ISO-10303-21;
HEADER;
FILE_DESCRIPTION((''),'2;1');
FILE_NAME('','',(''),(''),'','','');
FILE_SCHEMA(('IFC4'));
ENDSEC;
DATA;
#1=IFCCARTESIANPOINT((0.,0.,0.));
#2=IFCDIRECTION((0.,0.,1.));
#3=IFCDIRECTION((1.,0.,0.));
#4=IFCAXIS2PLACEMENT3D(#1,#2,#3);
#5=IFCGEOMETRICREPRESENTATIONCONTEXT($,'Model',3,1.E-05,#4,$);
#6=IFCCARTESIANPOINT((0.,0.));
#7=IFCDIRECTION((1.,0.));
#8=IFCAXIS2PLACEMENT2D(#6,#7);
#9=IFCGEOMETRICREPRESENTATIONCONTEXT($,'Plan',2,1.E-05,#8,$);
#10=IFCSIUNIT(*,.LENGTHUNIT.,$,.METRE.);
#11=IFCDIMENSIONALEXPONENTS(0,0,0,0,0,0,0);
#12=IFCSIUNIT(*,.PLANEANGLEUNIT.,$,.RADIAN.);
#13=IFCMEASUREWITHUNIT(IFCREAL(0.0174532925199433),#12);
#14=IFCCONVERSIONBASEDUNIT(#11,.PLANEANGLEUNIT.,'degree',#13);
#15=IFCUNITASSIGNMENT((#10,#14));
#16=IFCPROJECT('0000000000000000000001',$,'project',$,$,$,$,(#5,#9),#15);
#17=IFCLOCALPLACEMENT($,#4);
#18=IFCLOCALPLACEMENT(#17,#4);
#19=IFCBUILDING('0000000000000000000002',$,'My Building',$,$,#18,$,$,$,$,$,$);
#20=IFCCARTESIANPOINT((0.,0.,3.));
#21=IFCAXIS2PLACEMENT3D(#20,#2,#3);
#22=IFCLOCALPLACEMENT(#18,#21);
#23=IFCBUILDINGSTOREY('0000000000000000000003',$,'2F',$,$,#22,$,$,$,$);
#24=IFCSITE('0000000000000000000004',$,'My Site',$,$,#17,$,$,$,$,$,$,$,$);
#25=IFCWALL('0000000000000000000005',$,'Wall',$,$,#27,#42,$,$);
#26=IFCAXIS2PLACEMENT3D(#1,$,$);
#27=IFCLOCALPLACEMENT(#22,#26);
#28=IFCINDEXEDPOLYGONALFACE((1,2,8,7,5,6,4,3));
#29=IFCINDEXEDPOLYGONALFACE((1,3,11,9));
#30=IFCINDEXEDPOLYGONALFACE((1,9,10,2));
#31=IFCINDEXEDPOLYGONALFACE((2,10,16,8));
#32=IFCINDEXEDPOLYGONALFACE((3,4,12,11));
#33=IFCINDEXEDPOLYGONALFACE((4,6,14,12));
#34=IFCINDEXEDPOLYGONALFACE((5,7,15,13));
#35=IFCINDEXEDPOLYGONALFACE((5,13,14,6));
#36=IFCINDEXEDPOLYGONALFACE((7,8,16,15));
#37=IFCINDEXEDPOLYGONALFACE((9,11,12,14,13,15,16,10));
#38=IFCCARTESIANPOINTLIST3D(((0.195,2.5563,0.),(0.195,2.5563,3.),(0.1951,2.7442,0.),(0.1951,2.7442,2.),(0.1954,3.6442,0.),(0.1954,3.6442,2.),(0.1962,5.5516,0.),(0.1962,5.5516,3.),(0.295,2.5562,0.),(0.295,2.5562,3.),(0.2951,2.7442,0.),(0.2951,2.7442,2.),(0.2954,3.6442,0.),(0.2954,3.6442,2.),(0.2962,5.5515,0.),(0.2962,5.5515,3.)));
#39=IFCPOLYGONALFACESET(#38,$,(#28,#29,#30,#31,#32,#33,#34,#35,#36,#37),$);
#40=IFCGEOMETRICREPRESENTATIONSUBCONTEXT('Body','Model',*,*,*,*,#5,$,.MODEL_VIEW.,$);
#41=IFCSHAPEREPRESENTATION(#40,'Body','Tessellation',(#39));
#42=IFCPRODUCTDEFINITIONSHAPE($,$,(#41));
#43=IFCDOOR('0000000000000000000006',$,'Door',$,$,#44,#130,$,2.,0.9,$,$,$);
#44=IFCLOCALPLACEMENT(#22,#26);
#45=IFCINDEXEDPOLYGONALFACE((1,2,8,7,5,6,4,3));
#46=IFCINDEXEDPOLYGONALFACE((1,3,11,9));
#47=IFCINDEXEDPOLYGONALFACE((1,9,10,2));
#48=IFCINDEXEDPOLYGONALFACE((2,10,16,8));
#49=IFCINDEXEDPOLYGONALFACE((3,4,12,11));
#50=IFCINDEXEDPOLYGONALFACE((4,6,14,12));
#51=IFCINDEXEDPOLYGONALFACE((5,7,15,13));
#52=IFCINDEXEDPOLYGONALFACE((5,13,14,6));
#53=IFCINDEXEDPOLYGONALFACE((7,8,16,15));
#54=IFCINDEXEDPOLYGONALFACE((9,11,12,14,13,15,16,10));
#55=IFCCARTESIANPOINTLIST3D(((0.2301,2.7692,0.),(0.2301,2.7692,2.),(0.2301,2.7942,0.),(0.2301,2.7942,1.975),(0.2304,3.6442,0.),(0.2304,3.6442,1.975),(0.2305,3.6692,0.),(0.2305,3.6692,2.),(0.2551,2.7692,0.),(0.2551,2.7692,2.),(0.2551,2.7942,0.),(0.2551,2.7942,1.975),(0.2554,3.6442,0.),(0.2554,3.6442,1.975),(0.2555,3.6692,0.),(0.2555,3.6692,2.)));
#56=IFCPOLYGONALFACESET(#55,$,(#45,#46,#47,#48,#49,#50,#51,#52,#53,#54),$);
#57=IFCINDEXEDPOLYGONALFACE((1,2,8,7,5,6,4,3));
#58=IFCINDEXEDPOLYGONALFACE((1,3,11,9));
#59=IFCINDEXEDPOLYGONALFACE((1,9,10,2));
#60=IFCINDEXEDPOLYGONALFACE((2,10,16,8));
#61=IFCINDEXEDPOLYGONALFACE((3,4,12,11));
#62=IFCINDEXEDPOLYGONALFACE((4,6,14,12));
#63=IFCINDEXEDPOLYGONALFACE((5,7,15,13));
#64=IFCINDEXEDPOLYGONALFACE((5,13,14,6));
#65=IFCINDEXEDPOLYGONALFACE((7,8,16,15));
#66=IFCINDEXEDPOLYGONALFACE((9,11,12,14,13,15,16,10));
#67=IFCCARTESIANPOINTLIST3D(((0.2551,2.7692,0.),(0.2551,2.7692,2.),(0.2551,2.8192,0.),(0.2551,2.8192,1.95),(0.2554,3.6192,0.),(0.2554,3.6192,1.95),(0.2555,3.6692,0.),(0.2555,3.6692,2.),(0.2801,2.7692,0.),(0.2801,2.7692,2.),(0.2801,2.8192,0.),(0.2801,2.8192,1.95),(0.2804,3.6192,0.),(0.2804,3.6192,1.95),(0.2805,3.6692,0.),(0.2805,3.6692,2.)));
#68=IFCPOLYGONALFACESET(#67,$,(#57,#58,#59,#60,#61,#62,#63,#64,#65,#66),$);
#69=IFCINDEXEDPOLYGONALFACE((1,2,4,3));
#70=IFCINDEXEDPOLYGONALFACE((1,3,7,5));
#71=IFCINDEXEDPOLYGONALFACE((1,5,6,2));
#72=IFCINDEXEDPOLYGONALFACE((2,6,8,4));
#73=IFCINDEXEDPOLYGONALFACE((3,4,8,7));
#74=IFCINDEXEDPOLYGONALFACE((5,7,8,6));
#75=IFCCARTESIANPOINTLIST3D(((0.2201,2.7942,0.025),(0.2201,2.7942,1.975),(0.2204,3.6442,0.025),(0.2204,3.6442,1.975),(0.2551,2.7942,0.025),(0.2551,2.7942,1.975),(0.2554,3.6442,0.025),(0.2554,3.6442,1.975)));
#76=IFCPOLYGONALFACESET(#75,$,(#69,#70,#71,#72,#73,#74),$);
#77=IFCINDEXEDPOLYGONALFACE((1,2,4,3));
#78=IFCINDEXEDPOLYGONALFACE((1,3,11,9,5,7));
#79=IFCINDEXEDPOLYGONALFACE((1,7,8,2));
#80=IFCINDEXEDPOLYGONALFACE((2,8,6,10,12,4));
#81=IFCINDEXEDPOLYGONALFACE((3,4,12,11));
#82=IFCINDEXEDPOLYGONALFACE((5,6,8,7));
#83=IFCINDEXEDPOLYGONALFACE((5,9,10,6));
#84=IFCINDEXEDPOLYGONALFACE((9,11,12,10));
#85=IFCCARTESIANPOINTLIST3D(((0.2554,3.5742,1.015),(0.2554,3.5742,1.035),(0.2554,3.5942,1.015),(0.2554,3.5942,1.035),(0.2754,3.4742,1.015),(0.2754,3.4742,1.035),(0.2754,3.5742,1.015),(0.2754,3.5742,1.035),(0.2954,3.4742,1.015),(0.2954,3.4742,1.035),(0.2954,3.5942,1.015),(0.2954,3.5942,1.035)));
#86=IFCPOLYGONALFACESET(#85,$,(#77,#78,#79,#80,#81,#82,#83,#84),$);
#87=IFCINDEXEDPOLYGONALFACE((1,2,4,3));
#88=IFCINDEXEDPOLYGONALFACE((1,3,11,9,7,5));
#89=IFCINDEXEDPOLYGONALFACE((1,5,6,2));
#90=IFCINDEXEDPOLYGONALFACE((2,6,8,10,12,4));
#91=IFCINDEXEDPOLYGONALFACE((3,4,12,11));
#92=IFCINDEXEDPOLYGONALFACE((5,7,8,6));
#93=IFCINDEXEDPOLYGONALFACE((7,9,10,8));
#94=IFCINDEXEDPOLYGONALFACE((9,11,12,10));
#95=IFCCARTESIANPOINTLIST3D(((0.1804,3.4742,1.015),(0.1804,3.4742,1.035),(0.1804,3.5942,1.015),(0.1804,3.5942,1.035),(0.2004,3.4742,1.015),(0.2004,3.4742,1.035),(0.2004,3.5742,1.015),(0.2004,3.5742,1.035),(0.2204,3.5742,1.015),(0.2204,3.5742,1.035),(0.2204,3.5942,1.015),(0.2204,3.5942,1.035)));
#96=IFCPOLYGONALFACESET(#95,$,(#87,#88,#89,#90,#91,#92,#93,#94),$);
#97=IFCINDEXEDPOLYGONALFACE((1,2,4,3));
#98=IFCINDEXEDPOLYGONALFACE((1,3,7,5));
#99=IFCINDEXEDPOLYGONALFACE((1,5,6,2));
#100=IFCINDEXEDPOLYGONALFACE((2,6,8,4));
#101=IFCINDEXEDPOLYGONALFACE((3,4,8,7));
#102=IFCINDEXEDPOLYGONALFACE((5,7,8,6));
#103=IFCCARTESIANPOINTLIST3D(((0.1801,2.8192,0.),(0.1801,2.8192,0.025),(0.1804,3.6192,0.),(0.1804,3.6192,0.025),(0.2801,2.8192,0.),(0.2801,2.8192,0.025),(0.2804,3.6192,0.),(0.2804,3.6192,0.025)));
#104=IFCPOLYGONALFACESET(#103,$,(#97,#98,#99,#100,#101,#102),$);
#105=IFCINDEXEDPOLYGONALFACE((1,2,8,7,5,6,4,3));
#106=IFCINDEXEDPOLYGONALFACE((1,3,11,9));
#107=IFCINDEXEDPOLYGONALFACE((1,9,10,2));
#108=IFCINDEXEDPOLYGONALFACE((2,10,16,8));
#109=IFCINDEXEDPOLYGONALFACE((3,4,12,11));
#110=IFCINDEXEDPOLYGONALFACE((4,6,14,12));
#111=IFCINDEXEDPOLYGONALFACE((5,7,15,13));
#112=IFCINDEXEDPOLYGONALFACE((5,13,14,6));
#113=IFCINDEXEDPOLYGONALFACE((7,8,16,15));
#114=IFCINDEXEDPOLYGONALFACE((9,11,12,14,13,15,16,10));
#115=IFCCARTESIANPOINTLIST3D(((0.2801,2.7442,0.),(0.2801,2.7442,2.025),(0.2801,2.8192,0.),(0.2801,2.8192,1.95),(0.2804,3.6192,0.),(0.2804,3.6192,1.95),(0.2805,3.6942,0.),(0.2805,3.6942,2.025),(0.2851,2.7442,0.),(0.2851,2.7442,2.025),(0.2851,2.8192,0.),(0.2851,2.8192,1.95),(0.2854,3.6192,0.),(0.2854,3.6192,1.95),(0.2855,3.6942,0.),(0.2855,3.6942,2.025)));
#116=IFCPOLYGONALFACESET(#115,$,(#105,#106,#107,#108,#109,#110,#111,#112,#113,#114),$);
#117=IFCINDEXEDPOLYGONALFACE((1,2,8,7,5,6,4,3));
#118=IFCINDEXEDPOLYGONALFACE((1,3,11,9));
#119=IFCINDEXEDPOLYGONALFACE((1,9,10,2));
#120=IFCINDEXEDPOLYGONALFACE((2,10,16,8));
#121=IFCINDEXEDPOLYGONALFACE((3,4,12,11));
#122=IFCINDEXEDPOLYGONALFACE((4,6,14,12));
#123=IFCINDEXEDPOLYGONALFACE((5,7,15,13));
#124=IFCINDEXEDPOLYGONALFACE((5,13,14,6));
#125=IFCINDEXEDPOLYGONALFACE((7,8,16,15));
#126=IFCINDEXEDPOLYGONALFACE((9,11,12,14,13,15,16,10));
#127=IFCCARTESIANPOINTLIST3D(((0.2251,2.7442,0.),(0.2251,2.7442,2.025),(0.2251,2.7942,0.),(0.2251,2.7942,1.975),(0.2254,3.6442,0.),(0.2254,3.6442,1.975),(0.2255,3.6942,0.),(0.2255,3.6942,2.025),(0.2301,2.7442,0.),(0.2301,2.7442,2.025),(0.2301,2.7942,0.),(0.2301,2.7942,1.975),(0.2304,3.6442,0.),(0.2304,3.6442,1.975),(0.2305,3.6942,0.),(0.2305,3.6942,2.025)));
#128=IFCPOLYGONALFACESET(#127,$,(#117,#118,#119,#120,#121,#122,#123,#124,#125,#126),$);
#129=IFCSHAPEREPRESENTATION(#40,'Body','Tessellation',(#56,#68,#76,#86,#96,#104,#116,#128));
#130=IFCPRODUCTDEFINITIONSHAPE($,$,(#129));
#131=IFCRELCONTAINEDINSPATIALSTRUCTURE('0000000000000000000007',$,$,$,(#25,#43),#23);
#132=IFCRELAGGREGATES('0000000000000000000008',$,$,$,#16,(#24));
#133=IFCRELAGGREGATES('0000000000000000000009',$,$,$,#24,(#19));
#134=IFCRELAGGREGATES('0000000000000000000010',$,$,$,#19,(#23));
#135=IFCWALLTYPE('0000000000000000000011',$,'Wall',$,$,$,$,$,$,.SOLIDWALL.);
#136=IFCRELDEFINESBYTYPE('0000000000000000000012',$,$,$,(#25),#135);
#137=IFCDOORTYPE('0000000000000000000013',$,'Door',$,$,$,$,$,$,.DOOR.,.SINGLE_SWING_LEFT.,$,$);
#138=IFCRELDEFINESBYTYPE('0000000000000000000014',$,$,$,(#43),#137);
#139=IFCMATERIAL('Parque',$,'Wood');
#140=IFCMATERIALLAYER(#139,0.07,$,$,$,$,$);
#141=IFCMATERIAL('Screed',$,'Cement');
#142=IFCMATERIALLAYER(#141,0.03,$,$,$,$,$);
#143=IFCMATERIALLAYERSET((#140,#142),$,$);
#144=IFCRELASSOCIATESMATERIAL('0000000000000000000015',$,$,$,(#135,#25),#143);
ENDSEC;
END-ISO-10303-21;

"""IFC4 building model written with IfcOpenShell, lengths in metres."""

from ifc_helpers import new_model, entity, si_unit, converted_unit, frame, origin_with_axes, origin_2d_with_axis, place, context, subcontext, project, spatial, line, indexed_curve, outline, extrude, shape, source, transform, mapped, material, layer, layer_set, layer_usage, type_object, type_shapes, element, fill, save


model = new_model("IFC4")

# Units and contexts
model_context = context("Model", 3, precision=1e-05, world=origin_with_axes())
plan_context = context("Plan", 2, precision=1e-05, world=origin_2d_with_axis())
body_context_1 = subcontext(model_context, "Body", "Model", "MODEL_VIEW")
body_context_2 = subcontext(plan_context, "Body", "Plan", "PLAN_VIEW")
ifc_project = project(units=[si_unit("LENGTHUNIT", "METRE"), converted_unit("PLANEANGLEUNIT", "degree", entity("IfcReal", 0.0174532925199433), si_unit("PLANEANGLEUNIT", "RADIAN"), dimensions=[0, 0, 0, 0, 0, 0, 0])], contexts=[model_context, plan_context])

# Site, building, storey
site_placement = place(None, origin_with_axes())
site = spatial("IfcSite", under=ifc_project, at=site_placement, Name="My Site")
building_placement = place(site_placement, origin_with_axes())
building = spatial("IfcBuilding", under=site, at=building_placement, Name="My Building")
storey_placement = place(building_placement, frame((0.0, 0.0, 3.0), z_axis=(0.0, 0.0, 1.0), x_axis=(1.0, 0.0, 0.0)))
storey = spatial("IfcBuildingStorey", under=building, at=storey_placement, Name="2F")

# Shared definitions
ifc_material_1 = material(Name="Parque", Category="Wood")
ifc_layer_1 = layer(ifc_material_1, 0.07)
ifc_material_2 = material(Name="Screed", Category="Cement")
ifc_layer_2 = layer(ifc_material_2, 0.03)
ifc_layer_set = layer_set([ifc_layer_1, ifc_layer_2])
wall_type = type_object("IfcWallType", Name="Wall", PredefinedType="SOLIDWALL", material=ifc_layer_set)

# Wall, opening, door
ifc_layer_usage_1 = layer_usage(ifc_layer_set, "AXIS2", "POSITIVE", 0.0)
wall_1_placement = place(storey_placement, frame((0.1962, 5.5516, 0.0), z_axis=(0.0, 0.0, 1.0), x_axis=(-0.000399, -1.0, 0.0)))
wall_1 = element("IfcWall", 1, at=wall_1_placement, inside=storey, type_object=wall_type, material=ifc_layer_usage_1, Name="Wall", context=body_context_1, shape_type="SweptSolid", body=[
    extrude(outline(indexed_curve([(0.0, 0.0), (0.0, 0.1), (2.9953, 0.1), (2.9953, 0.0)], segments=[line(1, 2, 3, 4, 1)])), origin_with_axes(), (0.0, 0.0, 1.0), 3.0),
])
shared_shape_1 = source(origin_with_axes(), body_context_1, "Body", "SweptSolid", [
    extrude(outline(indexed_curve([(0.0, 0.0), (0.9, 0.0), (0.9, 2.0), (0.0, 2.0)], segments=[line(1, 2, 3, 4, 1)])), frame((0.0, -0.6, 0.0), z_axis=(0.0, -1.0, 0.0), x_axis=(1.0, 0.0, 0.0)), (0.0, 0.0, -1.0), 1.2),
])
opening_1_placement = place(wall_1_placement, frame((1.9074, 0.0, 0.0), z_axis=(0.0, 0.0, 1.0), x_axis=(1.0, 0.0, 0.0)))
opening_1 = element("IfcOpeningElement", 2, at=opening_1_placement, cuts=wall_1, PredefinedType="OPENING", context=body_context_1, shape_type="MappedRepresentation", body=[
    mapped(shared_shape_1, transform((0.0, 0.0, 0.0), x_axis=(1.0, 0.0, 0.0), y_axis=(0.0, 1.0, 0.0), z_axis=(0.0, 0.0, 1.0), scale=1.0)),
])
door_type_1 = type_object("IfcDoorType", Name="Door", OperationType="SINGLE_SWING_LEFT", PredefinedType="DOOR")
shared_shape_2 = source(origin_with_axes(), body_context_1, "Body", "SweptSolid", [
    extrude(outline(indexed_curve([(0.0, 0.0), (0.0, 2.0), (0.9, 2.0), (0.9, 0.0), (0.875, 0.0), (0.875, 1.975), (0.025, 1.975), (0.025, 0.0)], segments=[line(1, 2, 3, 4, 5, 6, 7, 8, 1)])), frame((0.0, 0.025, 0.0), z_axis=(0.0, -1.0, 0.0), x_axis=(1.0, 0.0, 0.0)), (0.0, 0.0, -1.0), 0.025),
    extrude(outline(indexed_curve([(0.0, 0.0), (0.0, 2.0), (0.9, 2.0), (0.9, 0.0), (0.85, 0.0), (0.85, 1.95), (0.05, 1.95), (0.05, 0.0)], segments=[line(1, 2, 3, 4, 5, 6, 7, 8, 1)])), frame((0.0, 0.0, 0.0), z_axis=(0.0, -1.0, 0.0), x_axis=(1.0, 0.0, 0.0)), (0.0, 0.0, -1.0), 0.025),
    extrude(outline(indexed_curve([(0.0, 0.0), (0.85, 0.0), (0.85, 0.035), (0.0, 0.035)], segments=[line(1, 2, 3, 4, 1)])), frame((0.025, 0.025, 0.025), z_axis=(0.0, 0.0, 1.0), x_axis=(1.0, 0.0, 0.0)), (0.0, 0.0, 1.0), 1.95),
    extrude(outline(indexed_curve([(0.0, 0.0), (0.0, -0.04), (-0.12, -0.04), (-0.12, -0.02), (-0.02, -0.02), (-0.02, 0.0)], segments=[line(1, 2, 3, 4, 5, 6, 1)])), frame((0.825, 0.025, 1.015), z_axis=(0.0, 0.0, 1.0), x_axis=(1.0, 0.0, 0.0)), (0.0, 0.0, 1.0), 0.02),
    extrude(outline(indexed_curve([(0.0, 0.0), (0.0, 0.04), (-0.12, 0.04), (-0.12, 0.02), (-0.02, 0.02), (-0.02, 0.0)], segments=[line(1, 2, 3, 4, 5, 6, 1)])), frame((0.825, 0.06, 1.015), z_axis=(0.0, 0.0, 1.0), x_axis=(1.0, 0.0, 0.0)), (0.0, 0.0, 1.0), 0.02),
    extrude(outline(indexed_curve([(0.0, 0.0), (0.8, 0.0), (0.8, 0.1), (0.0, 0.1)], segments=[line(1, 2, 3, 4, 1)])), frame((0.05, 0.0, 0.0), z_axis=(0.0, 0.0, 1.0), x_axis=(1.0, 0.0, 0.0)), (0.0, 0.0, 1.0), 0.025),
    extrude(outline(indexed_curve([(0.0, 0.0), (0.0, 2.025), (0.95, 2.025), (0.95, 0.0), (0.875, 0.0), (0.875, 1.95), (0.075, 1.95), (0.075, 0.0)], segments=[line(1, 2, 3, 4, 5, 6, 7, 8, 1)])), frame((-0.025, -0.005, 0.0), z_axis=(0.0, -1.0, 0.0), x_axis=(1.0, 0.0, 0.0)), (0.0, 0.0, -1.0), 0.005),
    extrude(outline(indexed_curve([(0.0, 0.0), (0.0, 2.025), (0.95, 2.025), (0.95, 0.0), (0.9, 0.0), (0.9, 1.975), (0.05, 1.975), (0.05, 0.0)], segments=[line(1, 2, 3, 4, 5, 6, 7, 8, 1)])), frame((-0.025, 0.05, 0.0), z_axis=(0.0, -1.0, 0.0), x_axis=(1.0, 0.0, 0.0)), (0.0, 0.0, -1.0), 0.005),
])
shared_shape_3 = source(origin_with_axes(), body_context_2, "Body", "Curve2D", [
    entity("IfcIndexedPolyCurve", entity("IfcCartesianPointList2D", [[0.0, 0.0], [0.0, 0.05], [0.025, 0.05], [0.025, 0.025], [0.05, 0.025], [0.05, 0.0]]), [entity("IfcLineIndex", [1, 2, 3, 4, 5, 6, 1])]),
    entity("IfcIndexedPolyCurve", entity("IfcCartesianPointList2D", [[0.9, 0.0], [0.9, 0.05], [0.875, 0.05], [0.875, 0.025], [0.85, 0.025], [0.85, 0.0]]), [entity("IfcLineIndex", [1, 2, 3, 4, 5, 6, 1])]),
    entity("IfcTrimmedCurve", entity("IfcEllipse", entity("IfcAxis2Placement2D", entity("IfcCartesianPoint", [0.06, 0.05]), entity("IfcDirection", [1.0, 0.0])), 0.815, 0.85), [entity("IfcCartesianPoint", [0.875, 0.05])], [entity("IfcCartesianPoint", [0.06, 0.9])], True, "CARTESIAN"),
    entity("IfcIndexedPolyCurve", entity("IfcCartesianPointList2D", [[0.025, 0.05], [0.06, 0.05], [0.06, 0.9], [0.025, 0.9]]), [entity("IfcLineIndex", [1, 2, 3, 4, 1])]),
])
type_shapes(door_type_1, [shared_shape_2, shared_shape_3])
door_1_placement = place(opening_1_placement, frame((0.875, 0.085, 0.0), z_axis=(0.0, 0.0, 1.0), x_axis=(-1.0, 0.0, 0.0)))
door_1 = element("IfcDoor", 3, at=door_1_placement, inside=storey, type_object=door_type_1, Name="Door", OverallHeight=2.0, OverallWidth=0.9, shapes=[
    shape(body_context_1, "Body", "MappedRepresentation", [mapped(shared_shape_2, transform((0.0, 0.0, 0.0), x_axis=(1.0, 0.0, 0.0), y_axis=(0.0, 1.0, 0.0), z_axis=(0.0, 0.0, 1.0), scale=1.0))]),
    shape(body_context_2, "Body", "MappedRepresentation", [mapped(shared_shape_3, transform((0.0, 0.0, 0.0), x_axis=(1.0, 0.0, 0.0), y_axis=(0.0, 1.0, 0.0), z_axis=(0.0, 0.0, 1.0), scale=1.0))]),
])
fill(opening_1, door_1)

save(model, "model.ifc")
